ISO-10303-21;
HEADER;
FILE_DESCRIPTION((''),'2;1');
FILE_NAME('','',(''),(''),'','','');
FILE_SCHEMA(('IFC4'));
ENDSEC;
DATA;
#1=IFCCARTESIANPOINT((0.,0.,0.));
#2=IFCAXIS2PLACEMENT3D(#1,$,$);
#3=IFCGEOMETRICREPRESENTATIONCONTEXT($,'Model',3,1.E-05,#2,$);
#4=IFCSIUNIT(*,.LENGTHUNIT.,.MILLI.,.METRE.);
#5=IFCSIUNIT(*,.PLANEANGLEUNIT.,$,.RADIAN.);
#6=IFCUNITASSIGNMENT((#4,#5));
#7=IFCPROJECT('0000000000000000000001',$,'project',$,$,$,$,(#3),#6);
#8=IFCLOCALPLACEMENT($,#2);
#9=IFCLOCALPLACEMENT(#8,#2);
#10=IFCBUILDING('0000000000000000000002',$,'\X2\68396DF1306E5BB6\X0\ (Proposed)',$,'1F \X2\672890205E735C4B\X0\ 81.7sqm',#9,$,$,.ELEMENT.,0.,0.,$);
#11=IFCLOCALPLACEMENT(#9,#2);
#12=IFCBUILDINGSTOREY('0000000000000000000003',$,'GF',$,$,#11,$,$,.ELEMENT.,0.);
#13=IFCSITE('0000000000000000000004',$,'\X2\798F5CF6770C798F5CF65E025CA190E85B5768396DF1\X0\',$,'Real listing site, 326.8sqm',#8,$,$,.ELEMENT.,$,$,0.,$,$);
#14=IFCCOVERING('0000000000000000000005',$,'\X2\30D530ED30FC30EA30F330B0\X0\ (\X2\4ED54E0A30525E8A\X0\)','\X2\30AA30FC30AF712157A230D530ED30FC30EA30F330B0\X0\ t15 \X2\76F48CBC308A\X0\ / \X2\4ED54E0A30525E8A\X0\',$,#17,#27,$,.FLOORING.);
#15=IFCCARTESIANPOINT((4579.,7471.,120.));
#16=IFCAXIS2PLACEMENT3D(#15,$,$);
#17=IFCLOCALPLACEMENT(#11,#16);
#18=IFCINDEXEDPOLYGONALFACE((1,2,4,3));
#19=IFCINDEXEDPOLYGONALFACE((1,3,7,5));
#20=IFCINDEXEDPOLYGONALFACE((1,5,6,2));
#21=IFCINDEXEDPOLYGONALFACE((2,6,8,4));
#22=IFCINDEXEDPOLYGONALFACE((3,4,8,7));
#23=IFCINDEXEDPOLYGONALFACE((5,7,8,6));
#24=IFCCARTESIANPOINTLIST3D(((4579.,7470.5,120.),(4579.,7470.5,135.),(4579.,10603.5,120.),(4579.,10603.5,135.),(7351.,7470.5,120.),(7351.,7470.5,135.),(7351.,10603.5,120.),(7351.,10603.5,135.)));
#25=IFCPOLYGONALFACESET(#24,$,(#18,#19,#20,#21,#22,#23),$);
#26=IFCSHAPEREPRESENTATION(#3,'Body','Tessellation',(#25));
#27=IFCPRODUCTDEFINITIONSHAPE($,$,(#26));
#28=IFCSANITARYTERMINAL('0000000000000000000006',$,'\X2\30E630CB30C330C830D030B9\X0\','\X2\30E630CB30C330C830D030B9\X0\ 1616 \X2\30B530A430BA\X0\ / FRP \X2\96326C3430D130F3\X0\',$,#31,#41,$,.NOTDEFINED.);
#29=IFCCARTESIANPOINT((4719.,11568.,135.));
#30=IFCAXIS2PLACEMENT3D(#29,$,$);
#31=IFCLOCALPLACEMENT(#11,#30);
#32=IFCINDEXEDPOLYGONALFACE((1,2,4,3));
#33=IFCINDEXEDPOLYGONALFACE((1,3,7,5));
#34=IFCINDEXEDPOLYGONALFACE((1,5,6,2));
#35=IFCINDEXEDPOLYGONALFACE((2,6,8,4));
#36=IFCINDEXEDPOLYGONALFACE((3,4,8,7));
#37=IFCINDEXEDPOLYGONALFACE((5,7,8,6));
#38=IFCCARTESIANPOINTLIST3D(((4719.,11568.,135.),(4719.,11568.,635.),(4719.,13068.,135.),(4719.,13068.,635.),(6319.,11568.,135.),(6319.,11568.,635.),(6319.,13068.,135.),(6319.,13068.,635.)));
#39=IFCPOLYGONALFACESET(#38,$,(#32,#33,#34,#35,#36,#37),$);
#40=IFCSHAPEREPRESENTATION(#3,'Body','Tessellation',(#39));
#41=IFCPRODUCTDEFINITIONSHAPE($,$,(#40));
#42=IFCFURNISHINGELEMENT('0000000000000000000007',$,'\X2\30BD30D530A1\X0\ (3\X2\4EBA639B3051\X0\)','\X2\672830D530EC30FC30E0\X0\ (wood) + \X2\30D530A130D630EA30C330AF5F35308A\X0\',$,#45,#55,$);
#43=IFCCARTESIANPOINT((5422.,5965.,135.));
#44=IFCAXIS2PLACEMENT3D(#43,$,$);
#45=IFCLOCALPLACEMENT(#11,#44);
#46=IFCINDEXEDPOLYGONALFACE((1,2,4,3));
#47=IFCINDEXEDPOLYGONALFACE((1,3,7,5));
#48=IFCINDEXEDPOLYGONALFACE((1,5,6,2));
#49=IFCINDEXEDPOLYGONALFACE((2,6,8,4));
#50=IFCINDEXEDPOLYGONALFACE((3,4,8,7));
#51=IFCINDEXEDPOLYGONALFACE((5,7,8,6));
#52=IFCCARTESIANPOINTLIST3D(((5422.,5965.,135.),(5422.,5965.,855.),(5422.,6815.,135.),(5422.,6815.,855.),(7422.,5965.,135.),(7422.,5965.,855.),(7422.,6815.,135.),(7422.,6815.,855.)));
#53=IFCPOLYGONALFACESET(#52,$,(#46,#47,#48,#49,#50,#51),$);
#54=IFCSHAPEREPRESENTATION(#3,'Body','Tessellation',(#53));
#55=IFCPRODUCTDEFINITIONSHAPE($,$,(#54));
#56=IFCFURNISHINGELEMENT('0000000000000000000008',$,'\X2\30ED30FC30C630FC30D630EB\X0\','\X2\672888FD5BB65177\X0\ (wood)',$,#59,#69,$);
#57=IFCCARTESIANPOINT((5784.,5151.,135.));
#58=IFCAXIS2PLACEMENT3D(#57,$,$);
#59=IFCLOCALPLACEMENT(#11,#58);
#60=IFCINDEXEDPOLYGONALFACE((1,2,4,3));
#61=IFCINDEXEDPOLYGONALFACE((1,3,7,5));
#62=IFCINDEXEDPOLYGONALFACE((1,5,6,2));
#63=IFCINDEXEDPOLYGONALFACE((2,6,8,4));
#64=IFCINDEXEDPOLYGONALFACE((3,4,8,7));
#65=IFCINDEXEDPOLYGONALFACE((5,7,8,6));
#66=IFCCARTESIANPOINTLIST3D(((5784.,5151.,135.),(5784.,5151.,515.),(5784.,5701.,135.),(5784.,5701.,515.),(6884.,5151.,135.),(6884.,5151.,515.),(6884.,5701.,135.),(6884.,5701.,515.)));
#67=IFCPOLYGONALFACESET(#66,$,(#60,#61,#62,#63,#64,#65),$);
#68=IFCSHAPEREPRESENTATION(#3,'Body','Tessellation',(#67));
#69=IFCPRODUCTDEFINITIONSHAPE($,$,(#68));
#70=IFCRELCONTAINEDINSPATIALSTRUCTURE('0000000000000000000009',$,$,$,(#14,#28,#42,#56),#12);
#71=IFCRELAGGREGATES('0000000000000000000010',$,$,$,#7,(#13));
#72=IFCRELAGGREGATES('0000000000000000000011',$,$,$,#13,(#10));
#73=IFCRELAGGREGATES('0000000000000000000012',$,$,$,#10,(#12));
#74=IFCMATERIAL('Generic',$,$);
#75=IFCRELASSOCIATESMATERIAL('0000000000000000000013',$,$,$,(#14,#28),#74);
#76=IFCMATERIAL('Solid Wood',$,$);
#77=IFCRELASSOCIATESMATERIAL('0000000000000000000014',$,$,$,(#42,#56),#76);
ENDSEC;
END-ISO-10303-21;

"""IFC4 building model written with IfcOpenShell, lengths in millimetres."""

from ifc_helpers import new_model, si_unit, frame, frame_2d, origin, place, context, project, spatial, rectangle, extrude, material, element, save


model = new_model("IFC4")

# Units and contexts
model_context = context("Model", 3, precision=1e-05, world=origin())
ifc_project = project(units=[si_unit("LENGTHUNIT", "METRE", prefix="MILLI"), si_unit("PLANEANGLEUNIT", "RADIAN")], contexts=[model_context])

# Site, building, storey
site_placement = place(None, origin())
site = spatial("IfcSite", under=ifc_project, at=site_placement, Name="福島県福島市岡部字根深", ObjectType="Real listing site, 326.8sqm", CompositionType="ELEMENT", RefElevation=0.0)
building_placement = place(site_placement, origin())
building = spatial("IfcBuilding", under=site, at=building_placement, Name="根深の家 (Proposed)", ObjectType="1F 木造平屋 81.7sqm", CompositionType="ELEMENT", ElevationOfRefHeight=0.0, ElevationOfTerrain=0.0)
storey_placement = place(building_placement, origin())
storey = spatial("IfcBuildingStorey", under=building, at=storey_placement, Name="GF", CompositionType="ELEMENT", Elevation=0.0)

# Shared definitions
ifc_material_1 = material(Name="Solid Wood")

# Covering
ifc_material_2 = material(Name="Generic")
covering_1_placement = place(storey_placement, frame((4579.0, 7471.0, 120.0)))
element("IfcCovering", 1, at=covering_1_placement, inside=storey, material=ifc_material_2, Name="フローリング (仕上げ床)", Description="オーク無垢フローリング t15 直貼り / 仕上げ床", PredefinedType="FLOORING", context=model_context, shape_type="SweptSolid", body=[
    extrude(rectangle(XDim=2772.0, YDim=3133.0, at=frame_2d((1386.0, 1566.0))), frame((4579.0, 7471.0, 120.0)), (0.0, 0.0, 1.0), 15.0),
])

# Sanitary terminal
sanitary_terminal_placement = place(storey_placement, frame((4719.0, 11568.0, 135.0)))
element("IfcSanitaryTerminal", 2, at=sanitary_terminal_placement, inside=storey, material=ifc_material_2, Name="ユニットバス", Description="ユニットバス 1616 サイズ / FRP 防水パン", PredefinedType="NOTDEFINED", context=model_context, shape_type="SweptSolid", body=[
    extrude(rectangle(XDim=1600.0, YDim=1500.0, at=frame_2d((800.0, 750.0))), frame((4719.0, 11568.0, 135.0)), (0.0, 0.0, 1.0), 500.0),
])

# Furnishing elements
furnishing_1_placement = place(storey_placement, frame((5422.0, 5965.0, 135.0)))
element("IfcFurnishingElement", 3, at=furnishing_1_placement, inside=storey, material=ifc_material_1, Name="ソファ (3人掛け)", Description="木フレーム (wood) + ファブリック張り", context=model_context, shape_type="SweptSolid", body=[
    extrude(rectangle(XDim=2000.0, YDim=850.0, at=frame_2d((1000.0, 425.0))), frame((5422.0, 5965.0, 135.0)), (0.0, 0.0, 1.0), 720.0),
])
furnishing_2_placement = place(storey_placement, frame((5784.0, 5151.0, 135.0)))
element("IfcFurnishingElement", 4, at=furnishing_2_placement, inside=storey, material=ifc_material_1, Name="ローテーブル", Description="木製家具 (wood)", context=model_context, shape_type="SweptSolid", body=[
    extrude(rectangle(XDim=1100.0, YDim=550.0, at=frame_2d((550.0, 275.0))), frame((5784.0, 5151.0, 135.0)), (0.0, 0.0, 1.0), 380.0),
])

save(model, "model.ifc")
